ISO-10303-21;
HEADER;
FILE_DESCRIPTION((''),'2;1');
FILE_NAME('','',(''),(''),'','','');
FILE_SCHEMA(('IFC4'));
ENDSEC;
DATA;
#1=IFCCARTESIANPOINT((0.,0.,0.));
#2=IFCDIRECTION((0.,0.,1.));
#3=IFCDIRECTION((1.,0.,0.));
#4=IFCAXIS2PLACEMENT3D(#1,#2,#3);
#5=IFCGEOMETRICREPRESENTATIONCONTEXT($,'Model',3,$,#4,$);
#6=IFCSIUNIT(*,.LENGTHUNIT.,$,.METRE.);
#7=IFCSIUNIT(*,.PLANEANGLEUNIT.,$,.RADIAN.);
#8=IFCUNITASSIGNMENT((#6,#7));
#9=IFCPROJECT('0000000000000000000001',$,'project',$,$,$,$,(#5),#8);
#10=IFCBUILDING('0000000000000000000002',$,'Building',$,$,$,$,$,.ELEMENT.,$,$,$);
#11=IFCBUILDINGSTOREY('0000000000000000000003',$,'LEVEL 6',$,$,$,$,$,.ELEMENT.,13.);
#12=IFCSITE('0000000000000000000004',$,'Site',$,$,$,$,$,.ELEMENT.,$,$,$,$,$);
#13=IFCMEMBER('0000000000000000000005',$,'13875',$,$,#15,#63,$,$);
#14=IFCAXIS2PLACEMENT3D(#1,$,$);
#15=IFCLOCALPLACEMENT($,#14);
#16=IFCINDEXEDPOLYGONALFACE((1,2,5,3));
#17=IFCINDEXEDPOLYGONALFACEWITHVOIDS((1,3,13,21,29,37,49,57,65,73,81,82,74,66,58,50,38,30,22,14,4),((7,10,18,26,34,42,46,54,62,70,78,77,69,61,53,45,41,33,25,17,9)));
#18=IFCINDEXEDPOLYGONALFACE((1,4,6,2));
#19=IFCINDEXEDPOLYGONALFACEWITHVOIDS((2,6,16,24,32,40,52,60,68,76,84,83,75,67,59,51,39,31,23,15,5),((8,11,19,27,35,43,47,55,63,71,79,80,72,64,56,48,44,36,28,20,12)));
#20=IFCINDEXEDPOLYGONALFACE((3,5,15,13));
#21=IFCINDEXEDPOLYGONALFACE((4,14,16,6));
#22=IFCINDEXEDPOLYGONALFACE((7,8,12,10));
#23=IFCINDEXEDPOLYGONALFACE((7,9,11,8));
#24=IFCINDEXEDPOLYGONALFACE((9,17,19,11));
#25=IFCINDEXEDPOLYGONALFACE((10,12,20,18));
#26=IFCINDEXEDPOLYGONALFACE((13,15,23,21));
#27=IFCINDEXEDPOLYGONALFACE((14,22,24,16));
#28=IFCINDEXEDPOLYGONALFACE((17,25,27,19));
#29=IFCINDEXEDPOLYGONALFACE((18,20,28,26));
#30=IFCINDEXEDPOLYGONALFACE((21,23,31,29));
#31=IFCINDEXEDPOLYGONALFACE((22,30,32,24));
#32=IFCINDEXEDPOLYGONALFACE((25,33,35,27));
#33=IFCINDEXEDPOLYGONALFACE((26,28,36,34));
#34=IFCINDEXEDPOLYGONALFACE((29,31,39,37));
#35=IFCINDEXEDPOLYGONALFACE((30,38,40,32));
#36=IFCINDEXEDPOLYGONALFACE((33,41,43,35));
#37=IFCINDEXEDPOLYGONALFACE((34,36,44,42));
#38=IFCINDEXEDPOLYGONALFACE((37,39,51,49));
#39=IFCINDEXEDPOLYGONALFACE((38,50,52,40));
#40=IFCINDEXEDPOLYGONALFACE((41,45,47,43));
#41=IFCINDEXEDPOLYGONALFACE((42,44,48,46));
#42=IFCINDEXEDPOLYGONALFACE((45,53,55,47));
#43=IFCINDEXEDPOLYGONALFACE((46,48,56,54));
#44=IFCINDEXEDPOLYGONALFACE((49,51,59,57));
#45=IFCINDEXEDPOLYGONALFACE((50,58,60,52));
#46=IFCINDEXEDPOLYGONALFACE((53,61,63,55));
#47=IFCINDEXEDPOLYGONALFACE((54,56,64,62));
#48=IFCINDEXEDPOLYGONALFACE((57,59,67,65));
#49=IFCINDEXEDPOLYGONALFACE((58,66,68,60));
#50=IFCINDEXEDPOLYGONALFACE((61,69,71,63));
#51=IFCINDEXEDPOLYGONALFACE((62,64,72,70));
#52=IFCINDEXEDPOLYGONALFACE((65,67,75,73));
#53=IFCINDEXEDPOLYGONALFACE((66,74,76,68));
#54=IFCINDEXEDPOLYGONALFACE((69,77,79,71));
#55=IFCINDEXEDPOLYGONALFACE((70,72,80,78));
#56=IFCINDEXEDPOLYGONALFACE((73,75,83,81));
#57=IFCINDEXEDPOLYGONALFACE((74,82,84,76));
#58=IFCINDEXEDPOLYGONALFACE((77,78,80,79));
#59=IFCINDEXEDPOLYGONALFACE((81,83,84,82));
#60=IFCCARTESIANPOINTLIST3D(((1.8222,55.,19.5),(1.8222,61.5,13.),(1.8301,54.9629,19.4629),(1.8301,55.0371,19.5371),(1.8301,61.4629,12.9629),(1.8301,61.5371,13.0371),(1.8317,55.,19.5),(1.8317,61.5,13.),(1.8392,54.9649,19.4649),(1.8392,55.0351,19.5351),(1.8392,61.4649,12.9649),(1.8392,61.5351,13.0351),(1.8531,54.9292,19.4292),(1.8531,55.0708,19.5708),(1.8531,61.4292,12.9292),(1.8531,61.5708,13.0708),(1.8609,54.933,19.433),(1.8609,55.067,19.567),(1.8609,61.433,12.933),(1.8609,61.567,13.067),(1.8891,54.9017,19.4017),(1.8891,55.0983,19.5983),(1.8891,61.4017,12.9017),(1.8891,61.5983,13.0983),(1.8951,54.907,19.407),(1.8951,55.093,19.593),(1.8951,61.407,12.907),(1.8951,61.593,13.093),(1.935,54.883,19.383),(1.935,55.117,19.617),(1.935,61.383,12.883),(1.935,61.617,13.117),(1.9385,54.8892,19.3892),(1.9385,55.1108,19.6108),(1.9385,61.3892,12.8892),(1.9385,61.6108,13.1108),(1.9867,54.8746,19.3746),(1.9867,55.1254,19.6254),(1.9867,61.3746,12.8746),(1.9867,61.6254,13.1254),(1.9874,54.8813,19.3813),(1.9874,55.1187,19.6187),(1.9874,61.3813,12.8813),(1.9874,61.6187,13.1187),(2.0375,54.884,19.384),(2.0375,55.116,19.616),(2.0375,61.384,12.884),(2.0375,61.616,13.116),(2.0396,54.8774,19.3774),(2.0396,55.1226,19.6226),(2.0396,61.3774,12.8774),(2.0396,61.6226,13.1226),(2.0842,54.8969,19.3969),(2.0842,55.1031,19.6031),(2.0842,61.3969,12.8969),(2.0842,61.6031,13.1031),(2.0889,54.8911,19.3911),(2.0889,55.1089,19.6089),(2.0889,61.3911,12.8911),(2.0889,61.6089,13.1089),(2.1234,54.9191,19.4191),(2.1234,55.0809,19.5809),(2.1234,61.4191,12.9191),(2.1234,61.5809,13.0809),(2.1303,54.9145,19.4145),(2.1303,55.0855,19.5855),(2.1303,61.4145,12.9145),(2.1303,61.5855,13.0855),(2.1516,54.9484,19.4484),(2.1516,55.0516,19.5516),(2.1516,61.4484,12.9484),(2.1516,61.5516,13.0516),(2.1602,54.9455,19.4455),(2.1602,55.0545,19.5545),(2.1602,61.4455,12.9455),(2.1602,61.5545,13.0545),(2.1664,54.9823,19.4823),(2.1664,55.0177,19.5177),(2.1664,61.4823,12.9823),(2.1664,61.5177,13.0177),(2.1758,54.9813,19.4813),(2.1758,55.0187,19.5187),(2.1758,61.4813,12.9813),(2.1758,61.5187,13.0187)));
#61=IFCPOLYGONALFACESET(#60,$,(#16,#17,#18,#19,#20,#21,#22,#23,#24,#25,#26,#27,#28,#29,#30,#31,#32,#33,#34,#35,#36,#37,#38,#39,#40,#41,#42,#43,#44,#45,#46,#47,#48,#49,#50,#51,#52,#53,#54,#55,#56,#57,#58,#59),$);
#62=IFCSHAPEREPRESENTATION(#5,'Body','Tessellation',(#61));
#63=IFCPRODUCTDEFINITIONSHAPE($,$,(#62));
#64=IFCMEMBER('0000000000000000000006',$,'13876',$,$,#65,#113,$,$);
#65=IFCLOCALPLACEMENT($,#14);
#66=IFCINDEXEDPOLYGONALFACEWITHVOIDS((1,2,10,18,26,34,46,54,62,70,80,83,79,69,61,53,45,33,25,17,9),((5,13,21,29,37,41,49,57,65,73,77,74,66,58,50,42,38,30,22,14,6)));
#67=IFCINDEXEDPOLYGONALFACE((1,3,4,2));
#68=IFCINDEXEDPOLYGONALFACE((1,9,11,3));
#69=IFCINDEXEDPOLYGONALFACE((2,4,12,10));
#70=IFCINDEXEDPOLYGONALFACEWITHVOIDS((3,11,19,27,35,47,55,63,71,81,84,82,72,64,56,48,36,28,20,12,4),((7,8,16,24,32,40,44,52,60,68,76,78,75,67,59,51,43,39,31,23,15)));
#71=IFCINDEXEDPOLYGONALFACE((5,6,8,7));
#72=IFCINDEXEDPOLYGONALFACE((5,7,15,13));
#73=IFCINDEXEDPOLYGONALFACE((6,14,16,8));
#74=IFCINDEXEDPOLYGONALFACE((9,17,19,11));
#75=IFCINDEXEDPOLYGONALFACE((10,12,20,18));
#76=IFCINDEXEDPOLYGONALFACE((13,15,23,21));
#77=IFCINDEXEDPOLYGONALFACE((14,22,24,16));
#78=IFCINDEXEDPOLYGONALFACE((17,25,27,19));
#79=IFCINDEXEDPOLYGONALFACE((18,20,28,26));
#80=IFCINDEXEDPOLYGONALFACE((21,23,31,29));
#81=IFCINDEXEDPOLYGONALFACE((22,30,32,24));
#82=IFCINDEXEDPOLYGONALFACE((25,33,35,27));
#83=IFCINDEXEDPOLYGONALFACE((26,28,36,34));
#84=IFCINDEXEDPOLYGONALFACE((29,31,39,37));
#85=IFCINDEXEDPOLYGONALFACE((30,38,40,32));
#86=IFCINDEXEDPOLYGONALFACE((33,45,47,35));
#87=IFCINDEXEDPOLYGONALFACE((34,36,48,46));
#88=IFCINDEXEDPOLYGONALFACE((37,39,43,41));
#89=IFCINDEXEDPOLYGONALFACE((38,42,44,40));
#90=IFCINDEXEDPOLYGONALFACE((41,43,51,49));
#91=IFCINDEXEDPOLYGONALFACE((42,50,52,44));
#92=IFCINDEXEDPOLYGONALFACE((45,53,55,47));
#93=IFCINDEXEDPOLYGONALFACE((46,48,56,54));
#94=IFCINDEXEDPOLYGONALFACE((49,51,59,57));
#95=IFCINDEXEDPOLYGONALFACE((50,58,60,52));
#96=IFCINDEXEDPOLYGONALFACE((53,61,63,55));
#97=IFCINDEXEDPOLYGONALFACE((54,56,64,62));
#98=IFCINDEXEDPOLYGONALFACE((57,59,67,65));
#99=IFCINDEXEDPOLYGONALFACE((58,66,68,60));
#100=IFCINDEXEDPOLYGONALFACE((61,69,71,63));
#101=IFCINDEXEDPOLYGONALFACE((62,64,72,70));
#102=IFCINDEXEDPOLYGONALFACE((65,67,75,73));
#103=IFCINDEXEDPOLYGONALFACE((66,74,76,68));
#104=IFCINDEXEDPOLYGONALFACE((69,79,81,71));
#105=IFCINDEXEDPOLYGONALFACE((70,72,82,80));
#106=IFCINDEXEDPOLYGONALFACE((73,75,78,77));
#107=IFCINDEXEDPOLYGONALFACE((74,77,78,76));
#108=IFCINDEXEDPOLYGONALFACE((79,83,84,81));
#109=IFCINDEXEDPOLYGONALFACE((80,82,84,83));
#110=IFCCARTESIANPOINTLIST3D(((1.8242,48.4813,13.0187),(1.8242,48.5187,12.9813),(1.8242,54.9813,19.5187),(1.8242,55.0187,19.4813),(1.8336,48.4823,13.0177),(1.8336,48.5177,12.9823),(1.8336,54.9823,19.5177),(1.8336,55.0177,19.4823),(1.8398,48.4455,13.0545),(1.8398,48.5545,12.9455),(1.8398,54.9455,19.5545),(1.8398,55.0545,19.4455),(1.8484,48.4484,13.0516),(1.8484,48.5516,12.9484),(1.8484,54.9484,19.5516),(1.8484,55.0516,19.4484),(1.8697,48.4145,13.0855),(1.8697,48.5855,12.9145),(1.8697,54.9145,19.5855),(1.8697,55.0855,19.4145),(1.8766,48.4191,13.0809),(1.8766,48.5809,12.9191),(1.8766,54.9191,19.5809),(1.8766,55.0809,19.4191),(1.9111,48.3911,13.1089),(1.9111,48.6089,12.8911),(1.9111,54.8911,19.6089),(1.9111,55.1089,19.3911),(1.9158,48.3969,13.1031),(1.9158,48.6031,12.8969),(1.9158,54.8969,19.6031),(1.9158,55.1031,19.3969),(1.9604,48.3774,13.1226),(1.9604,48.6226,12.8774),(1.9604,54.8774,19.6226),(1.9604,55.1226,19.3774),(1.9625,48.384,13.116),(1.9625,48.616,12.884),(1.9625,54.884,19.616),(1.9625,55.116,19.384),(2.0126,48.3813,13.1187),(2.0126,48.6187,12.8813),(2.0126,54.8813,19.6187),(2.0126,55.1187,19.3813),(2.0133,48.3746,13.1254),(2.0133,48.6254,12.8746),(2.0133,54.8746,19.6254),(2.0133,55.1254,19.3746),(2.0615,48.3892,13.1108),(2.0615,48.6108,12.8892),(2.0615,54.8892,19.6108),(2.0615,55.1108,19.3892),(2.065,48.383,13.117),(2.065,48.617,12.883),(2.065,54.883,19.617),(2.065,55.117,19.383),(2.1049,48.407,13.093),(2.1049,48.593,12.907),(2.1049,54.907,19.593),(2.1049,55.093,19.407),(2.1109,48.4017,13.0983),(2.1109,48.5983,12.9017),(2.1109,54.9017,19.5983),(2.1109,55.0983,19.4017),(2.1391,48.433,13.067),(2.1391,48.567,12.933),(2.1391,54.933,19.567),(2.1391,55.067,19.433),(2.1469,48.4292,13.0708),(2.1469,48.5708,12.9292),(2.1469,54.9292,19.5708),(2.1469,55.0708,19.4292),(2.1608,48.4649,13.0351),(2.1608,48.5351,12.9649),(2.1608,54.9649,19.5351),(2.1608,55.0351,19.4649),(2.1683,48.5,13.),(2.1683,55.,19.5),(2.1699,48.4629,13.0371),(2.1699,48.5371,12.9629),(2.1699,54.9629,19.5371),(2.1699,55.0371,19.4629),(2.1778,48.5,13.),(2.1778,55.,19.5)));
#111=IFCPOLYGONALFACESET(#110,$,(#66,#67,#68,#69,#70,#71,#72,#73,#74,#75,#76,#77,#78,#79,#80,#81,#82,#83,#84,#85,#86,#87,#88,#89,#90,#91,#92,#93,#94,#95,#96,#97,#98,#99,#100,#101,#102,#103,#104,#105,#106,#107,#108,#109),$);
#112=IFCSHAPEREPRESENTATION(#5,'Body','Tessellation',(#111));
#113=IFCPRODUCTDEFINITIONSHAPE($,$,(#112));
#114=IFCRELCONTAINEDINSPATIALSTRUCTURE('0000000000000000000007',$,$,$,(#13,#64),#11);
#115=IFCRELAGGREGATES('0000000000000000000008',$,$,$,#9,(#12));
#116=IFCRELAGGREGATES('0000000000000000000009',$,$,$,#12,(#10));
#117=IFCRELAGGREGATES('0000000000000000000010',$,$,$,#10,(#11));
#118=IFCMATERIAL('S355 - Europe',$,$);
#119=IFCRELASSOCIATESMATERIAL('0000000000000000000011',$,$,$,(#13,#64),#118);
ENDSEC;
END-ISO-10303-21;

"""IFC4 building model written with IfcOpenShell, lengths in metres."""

from ifc_helpers import new_model, si_unit, frame, origin_with_axes, origin_2d_with_axis, place, context, project, spatial, hollow_circle, extrude, material, material_profile, profile_set, profile_usage, element, save


model = new_model("IFC4")

# Units and contexts
model_context = context("Model", 3, world=origin_with_axes())
ifc_project = project(units=[si_unit("LENGTHUNIT", "METRE"), si_unit("PLANEANGLEUNIT", "RADIAN")], contexts=[model_context])

# Site, building, storey
site = spatial("IfcSite", under=ifc_project, Name="Site", CompositionType="ELEMENT")
building = spatial("IfcBuilding", under=site, Name="Building", CompositionType="ELEMENT")
storey = spatial("IfcBuildingStorey", under=building, Name="LEVEL 6", CompositionType="ELEMENT", Elevation=13.0)

# Shared definitions
ifc_material = material(Name="S355 - Europe")

# Members
ifc_material_profile_1 = material_profile(ifc_material, hollow_circle(Radius=0.1778, WallThickness=0.0095, at=origin_2d_with_axis()))
ifc_profile_set_1 = profile_set([ifc_material_profile_1])
ifc_profile_usage_1 = profile_usage(ifc_profile_set_1, cardinal=10)
member_1_placement = place(None, frame((2.0, 55.0, 19.5), z_axis=(0.0, 0.707107, -0.707107), x_axis=(-1.0, 0.0, 0.0)))
element("IfcMember", 1, at=member_1_placement, inside=storey, material=ifc_profile_usage_1, Name="13875", context=model_context, shape_type="SweptSolid", body=[
    extrude(hollow_circle(Radius=0.1778, WallThickness=0.0095, at=origin_2d_with_axis()), origin_with_axes(), (0.0, 0.0, 1.0), 9.1924),
])
ifc_material_profile_2 = material_profile(ifc_material, hollow_circle(Radius=0.1778, WallThickness=0.0095, at=origin_2d_with_axis()))
ifc_profile_set_2 = profile_set([ifc_material_profile_2])
ifc_profile_usage_2 = profile_usage(ifc_profile_set_2, cardinal=10)
member_2_placement = place(None, frame((2.0, 55.0, 19.5), z_axis=(0.0, -0.707107, -0.707107), x_axis=(1.0, 0.0, 0.0)))
element("IfcMember", 2, at=member_2_placement, inside=storey, material=ifc_profile_usage_2, Name="13876", context=model_context, shape_type="SweptSolid", body=[
    extrude(hollow_circle(Radius=0.1778, WallThickness=0.0095, at=origin_2d_with_axis()), origin_with_axes(), (0.0, 0.0, 1.0), 9.1924),
])

save(model, "model.ifc")
